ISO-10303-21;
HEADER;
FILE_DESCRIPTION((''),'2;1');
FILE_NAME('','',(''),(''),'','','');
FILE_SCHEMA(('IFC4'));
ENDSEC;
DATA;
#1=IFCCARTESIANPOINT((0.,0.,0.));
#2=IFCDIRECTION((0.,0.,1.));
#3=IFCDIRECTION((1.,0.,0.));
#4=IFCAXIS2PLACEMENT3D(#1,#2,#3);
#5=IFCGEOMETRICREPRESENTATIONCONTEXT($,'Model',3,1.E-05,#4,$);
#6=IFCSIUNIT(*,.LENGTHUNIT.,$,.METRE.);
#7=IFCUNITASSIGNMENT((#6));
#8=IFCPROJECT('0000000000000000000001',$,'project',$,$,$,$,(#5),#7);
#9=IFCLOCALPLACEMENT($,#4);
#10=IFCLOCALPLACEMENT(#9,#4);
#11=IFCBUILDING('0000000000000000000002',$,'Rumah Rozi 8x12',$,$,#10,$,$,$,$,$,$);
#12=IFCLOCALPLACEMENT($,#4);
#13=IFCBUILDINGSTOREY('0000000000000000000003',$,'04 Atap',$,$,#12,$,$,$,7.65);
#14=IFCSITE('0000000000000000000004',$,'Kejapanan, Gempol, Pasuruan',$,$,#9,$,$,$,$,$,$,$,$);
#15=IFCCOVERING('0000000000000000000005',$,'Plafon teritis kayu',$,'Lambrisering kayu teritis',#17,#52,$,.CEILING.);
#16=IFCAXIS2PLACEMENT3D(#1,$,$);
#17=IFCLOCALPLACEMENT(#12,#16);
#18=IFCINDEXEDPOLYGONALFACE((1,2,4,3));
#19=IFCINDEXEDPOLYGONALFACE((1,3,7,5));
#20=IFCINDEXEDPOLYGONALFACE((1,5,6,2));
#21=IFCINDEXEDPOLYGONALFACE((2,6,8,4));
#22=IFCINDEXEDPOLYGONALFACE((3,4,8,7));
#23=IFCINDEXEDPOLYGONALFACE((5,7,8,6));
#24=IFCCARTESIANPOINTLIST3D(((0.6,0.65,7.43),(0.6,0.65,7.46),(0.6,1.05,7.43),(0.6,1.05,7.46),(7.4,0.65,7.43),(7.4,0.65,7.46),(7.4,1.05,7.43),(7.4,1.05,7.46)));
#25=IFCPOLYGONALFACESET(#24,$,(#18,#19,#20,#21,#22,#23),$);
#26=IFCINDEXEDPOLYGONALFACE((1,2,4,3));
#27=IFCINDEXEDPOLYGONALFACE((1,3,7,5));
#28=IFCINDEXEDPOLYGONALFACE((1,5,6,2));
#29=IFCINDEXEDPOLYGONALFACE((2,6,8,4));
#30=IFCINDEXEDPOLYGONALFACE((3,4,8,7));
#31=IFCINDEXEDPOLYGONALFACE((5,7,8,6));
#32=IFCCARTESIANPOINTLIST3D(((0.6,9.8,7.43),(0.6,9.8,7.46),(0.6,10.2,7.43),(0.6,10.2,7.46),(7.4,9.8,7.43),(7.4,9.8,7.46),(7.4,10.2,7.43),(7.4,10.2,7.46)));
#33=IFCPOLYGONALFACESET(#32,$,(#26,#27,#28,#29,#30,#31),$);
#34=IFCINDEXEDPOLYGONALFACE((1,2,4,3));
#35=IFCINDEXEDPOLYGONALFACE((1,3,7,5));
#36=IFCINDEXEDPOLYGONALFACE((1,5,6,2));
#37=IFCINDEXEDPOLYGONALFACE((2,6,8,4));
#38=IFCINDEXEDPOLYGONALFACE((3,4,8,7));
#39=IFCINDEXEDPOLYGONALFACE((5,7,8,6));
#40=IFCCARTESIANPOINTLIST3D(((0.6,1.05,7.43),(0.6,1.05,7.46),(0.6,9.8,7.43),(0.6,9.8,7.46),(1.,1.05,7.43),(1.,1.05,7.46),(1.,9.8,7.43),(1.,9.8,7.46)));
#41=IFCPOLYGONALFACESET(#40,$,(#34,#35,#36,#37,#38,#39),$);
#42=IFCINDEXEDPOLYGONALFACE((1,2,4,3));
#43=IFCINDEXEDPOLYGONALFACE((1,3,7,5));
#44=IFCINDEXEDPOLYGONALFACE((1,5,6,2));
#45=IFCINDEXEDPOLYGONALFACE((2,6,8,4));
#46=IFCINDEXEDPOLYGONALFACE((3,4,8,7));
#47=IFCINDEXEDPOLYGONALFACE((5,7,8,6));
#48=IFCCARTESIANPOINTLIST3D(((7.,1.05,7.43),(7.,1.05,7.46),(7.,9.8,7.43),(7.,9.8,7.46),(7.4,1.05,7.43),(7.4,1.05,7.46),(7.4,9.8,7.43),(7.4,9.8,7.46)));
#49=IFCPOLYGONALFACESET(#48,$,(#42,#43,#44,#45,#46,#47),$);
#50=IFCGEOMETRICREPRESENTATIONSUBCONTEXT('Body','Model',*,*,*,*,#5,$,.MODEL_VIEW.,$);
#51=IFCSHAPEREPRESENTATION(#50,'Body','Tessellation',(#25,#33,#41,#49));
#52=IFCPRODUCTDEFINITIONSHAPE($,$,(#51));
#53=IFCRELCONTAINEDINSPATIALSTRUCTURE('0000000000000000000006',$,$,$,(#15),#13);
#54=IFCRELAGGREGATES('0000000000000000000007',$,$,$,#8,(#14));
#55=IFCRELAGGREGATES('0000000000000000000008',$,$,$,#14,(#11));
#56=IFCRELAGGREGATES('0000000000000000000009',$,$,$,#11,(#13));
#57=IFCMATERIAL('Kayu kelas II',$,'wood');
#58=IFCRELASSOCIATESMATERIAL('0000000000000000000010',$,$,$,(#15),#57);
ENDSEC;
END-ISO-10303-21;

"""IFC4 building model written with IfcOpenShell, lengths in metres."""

from ifc_helpers import new_model, si_unit, frame, origin_with_axes, place, context, subcontext, project, spatial, line, indexed_curve, outline, extrude, material, element, save


model = new_model("IFC4")

# Units and contexts
model_context = context("Model", 3, precision=1e-05, world=origin_with_axes())
body_context = subcontext(model_context, "Body", "Model", "MODEL_VIEW")
ifc_project = project(units=[si_unit("LENGTHUNIT", "METRE")], contexts=[model_context])

# Site, building, storey
site_placement = place(None, origin_with_axes())
site = spatial("IfcSite", under=ifc_project, at=site_placement, Name="Kejapanan, Gempol, Pasuruan")
building_placement = place(site_placement, origin_with_axes())
building = spatial("IfcBuilding", under=site, at=building_placement, Name="Rumah Rozi 8x12")
storey_placement = place(None, origin_with_axes())
storey = spatial("IfcBuildingStorey", under=building, at=storey_placement, Name="04 Atap", Elevation=7.65)

# Covering
ifc_material = material(Name="Kayu kelas II", Category="wood")
covering_placement = place(storey_placement, origin_with_axes())
element("IfcCovering", 1, at=covering_placement, inside=storey, material=ifc_material, Name="Plafon teritis kayu", ObjectType="Lambrisering kayu teritis", PredefinedType="CEILING", context=body_context, shape_type="SweptSolid", body=[
    extrude(outline(indexed_curve([(0.6, 0.65), (7.4, 0.65), (7.4, 1.05), (0.6, 1.05)], segments=[line(1, 2, 3, 4, 1)])), frame((0.0, 0.0, 7.43), z_axis=(0.0, 0.0, 1.0), x_axis=(1.0, 0.0, 0.0)), (0.0, 0.0, 1.0), 0.03),
    extrude(outline(indexed_curve([(0.6, 9.8), (7.4, 9.8), (7.4, 10.2), (0.6, 10.2)], segments=[line(1, 2, 3, 4, 1)])), frame((0.0, 0.0, 7.43), z_axis=(0.0, 0.0, 1.0), x_axis=(1.0, 0.0, 0.0)), (0.0, 0.0, 1.0), 0.03),
    extrude(outline(indexed_curve([(0.6, 1.05), (1.0, 1.05), (1.0, 9.8), (0.6, 9.8)], segments=[line(1, 2, 3, 4, 1)])), frame((0.0, 0.0, 7.43), z_axis=(0.0, 0.0, 1.0), x_axis=(1.0, 0.0, 0.0)), (0.0, 0.0, 1.0), 0.03),
    extrude(outline(indexed_curve([(7.0, 1.05), (7.4, 1.05), (7.4, 9.8), (7.0, 9.8)], segments=[line(1, 2, 3, 4, 1)])), frame((0.0, 0.0, 7.43), z_axis=(0.0, 0.0, 1.0), x_axis=(1.0, 0.0, 0.0)), (0.0, 0.0, 1.0), 0.03),
])

save(model, "model.ifc")
